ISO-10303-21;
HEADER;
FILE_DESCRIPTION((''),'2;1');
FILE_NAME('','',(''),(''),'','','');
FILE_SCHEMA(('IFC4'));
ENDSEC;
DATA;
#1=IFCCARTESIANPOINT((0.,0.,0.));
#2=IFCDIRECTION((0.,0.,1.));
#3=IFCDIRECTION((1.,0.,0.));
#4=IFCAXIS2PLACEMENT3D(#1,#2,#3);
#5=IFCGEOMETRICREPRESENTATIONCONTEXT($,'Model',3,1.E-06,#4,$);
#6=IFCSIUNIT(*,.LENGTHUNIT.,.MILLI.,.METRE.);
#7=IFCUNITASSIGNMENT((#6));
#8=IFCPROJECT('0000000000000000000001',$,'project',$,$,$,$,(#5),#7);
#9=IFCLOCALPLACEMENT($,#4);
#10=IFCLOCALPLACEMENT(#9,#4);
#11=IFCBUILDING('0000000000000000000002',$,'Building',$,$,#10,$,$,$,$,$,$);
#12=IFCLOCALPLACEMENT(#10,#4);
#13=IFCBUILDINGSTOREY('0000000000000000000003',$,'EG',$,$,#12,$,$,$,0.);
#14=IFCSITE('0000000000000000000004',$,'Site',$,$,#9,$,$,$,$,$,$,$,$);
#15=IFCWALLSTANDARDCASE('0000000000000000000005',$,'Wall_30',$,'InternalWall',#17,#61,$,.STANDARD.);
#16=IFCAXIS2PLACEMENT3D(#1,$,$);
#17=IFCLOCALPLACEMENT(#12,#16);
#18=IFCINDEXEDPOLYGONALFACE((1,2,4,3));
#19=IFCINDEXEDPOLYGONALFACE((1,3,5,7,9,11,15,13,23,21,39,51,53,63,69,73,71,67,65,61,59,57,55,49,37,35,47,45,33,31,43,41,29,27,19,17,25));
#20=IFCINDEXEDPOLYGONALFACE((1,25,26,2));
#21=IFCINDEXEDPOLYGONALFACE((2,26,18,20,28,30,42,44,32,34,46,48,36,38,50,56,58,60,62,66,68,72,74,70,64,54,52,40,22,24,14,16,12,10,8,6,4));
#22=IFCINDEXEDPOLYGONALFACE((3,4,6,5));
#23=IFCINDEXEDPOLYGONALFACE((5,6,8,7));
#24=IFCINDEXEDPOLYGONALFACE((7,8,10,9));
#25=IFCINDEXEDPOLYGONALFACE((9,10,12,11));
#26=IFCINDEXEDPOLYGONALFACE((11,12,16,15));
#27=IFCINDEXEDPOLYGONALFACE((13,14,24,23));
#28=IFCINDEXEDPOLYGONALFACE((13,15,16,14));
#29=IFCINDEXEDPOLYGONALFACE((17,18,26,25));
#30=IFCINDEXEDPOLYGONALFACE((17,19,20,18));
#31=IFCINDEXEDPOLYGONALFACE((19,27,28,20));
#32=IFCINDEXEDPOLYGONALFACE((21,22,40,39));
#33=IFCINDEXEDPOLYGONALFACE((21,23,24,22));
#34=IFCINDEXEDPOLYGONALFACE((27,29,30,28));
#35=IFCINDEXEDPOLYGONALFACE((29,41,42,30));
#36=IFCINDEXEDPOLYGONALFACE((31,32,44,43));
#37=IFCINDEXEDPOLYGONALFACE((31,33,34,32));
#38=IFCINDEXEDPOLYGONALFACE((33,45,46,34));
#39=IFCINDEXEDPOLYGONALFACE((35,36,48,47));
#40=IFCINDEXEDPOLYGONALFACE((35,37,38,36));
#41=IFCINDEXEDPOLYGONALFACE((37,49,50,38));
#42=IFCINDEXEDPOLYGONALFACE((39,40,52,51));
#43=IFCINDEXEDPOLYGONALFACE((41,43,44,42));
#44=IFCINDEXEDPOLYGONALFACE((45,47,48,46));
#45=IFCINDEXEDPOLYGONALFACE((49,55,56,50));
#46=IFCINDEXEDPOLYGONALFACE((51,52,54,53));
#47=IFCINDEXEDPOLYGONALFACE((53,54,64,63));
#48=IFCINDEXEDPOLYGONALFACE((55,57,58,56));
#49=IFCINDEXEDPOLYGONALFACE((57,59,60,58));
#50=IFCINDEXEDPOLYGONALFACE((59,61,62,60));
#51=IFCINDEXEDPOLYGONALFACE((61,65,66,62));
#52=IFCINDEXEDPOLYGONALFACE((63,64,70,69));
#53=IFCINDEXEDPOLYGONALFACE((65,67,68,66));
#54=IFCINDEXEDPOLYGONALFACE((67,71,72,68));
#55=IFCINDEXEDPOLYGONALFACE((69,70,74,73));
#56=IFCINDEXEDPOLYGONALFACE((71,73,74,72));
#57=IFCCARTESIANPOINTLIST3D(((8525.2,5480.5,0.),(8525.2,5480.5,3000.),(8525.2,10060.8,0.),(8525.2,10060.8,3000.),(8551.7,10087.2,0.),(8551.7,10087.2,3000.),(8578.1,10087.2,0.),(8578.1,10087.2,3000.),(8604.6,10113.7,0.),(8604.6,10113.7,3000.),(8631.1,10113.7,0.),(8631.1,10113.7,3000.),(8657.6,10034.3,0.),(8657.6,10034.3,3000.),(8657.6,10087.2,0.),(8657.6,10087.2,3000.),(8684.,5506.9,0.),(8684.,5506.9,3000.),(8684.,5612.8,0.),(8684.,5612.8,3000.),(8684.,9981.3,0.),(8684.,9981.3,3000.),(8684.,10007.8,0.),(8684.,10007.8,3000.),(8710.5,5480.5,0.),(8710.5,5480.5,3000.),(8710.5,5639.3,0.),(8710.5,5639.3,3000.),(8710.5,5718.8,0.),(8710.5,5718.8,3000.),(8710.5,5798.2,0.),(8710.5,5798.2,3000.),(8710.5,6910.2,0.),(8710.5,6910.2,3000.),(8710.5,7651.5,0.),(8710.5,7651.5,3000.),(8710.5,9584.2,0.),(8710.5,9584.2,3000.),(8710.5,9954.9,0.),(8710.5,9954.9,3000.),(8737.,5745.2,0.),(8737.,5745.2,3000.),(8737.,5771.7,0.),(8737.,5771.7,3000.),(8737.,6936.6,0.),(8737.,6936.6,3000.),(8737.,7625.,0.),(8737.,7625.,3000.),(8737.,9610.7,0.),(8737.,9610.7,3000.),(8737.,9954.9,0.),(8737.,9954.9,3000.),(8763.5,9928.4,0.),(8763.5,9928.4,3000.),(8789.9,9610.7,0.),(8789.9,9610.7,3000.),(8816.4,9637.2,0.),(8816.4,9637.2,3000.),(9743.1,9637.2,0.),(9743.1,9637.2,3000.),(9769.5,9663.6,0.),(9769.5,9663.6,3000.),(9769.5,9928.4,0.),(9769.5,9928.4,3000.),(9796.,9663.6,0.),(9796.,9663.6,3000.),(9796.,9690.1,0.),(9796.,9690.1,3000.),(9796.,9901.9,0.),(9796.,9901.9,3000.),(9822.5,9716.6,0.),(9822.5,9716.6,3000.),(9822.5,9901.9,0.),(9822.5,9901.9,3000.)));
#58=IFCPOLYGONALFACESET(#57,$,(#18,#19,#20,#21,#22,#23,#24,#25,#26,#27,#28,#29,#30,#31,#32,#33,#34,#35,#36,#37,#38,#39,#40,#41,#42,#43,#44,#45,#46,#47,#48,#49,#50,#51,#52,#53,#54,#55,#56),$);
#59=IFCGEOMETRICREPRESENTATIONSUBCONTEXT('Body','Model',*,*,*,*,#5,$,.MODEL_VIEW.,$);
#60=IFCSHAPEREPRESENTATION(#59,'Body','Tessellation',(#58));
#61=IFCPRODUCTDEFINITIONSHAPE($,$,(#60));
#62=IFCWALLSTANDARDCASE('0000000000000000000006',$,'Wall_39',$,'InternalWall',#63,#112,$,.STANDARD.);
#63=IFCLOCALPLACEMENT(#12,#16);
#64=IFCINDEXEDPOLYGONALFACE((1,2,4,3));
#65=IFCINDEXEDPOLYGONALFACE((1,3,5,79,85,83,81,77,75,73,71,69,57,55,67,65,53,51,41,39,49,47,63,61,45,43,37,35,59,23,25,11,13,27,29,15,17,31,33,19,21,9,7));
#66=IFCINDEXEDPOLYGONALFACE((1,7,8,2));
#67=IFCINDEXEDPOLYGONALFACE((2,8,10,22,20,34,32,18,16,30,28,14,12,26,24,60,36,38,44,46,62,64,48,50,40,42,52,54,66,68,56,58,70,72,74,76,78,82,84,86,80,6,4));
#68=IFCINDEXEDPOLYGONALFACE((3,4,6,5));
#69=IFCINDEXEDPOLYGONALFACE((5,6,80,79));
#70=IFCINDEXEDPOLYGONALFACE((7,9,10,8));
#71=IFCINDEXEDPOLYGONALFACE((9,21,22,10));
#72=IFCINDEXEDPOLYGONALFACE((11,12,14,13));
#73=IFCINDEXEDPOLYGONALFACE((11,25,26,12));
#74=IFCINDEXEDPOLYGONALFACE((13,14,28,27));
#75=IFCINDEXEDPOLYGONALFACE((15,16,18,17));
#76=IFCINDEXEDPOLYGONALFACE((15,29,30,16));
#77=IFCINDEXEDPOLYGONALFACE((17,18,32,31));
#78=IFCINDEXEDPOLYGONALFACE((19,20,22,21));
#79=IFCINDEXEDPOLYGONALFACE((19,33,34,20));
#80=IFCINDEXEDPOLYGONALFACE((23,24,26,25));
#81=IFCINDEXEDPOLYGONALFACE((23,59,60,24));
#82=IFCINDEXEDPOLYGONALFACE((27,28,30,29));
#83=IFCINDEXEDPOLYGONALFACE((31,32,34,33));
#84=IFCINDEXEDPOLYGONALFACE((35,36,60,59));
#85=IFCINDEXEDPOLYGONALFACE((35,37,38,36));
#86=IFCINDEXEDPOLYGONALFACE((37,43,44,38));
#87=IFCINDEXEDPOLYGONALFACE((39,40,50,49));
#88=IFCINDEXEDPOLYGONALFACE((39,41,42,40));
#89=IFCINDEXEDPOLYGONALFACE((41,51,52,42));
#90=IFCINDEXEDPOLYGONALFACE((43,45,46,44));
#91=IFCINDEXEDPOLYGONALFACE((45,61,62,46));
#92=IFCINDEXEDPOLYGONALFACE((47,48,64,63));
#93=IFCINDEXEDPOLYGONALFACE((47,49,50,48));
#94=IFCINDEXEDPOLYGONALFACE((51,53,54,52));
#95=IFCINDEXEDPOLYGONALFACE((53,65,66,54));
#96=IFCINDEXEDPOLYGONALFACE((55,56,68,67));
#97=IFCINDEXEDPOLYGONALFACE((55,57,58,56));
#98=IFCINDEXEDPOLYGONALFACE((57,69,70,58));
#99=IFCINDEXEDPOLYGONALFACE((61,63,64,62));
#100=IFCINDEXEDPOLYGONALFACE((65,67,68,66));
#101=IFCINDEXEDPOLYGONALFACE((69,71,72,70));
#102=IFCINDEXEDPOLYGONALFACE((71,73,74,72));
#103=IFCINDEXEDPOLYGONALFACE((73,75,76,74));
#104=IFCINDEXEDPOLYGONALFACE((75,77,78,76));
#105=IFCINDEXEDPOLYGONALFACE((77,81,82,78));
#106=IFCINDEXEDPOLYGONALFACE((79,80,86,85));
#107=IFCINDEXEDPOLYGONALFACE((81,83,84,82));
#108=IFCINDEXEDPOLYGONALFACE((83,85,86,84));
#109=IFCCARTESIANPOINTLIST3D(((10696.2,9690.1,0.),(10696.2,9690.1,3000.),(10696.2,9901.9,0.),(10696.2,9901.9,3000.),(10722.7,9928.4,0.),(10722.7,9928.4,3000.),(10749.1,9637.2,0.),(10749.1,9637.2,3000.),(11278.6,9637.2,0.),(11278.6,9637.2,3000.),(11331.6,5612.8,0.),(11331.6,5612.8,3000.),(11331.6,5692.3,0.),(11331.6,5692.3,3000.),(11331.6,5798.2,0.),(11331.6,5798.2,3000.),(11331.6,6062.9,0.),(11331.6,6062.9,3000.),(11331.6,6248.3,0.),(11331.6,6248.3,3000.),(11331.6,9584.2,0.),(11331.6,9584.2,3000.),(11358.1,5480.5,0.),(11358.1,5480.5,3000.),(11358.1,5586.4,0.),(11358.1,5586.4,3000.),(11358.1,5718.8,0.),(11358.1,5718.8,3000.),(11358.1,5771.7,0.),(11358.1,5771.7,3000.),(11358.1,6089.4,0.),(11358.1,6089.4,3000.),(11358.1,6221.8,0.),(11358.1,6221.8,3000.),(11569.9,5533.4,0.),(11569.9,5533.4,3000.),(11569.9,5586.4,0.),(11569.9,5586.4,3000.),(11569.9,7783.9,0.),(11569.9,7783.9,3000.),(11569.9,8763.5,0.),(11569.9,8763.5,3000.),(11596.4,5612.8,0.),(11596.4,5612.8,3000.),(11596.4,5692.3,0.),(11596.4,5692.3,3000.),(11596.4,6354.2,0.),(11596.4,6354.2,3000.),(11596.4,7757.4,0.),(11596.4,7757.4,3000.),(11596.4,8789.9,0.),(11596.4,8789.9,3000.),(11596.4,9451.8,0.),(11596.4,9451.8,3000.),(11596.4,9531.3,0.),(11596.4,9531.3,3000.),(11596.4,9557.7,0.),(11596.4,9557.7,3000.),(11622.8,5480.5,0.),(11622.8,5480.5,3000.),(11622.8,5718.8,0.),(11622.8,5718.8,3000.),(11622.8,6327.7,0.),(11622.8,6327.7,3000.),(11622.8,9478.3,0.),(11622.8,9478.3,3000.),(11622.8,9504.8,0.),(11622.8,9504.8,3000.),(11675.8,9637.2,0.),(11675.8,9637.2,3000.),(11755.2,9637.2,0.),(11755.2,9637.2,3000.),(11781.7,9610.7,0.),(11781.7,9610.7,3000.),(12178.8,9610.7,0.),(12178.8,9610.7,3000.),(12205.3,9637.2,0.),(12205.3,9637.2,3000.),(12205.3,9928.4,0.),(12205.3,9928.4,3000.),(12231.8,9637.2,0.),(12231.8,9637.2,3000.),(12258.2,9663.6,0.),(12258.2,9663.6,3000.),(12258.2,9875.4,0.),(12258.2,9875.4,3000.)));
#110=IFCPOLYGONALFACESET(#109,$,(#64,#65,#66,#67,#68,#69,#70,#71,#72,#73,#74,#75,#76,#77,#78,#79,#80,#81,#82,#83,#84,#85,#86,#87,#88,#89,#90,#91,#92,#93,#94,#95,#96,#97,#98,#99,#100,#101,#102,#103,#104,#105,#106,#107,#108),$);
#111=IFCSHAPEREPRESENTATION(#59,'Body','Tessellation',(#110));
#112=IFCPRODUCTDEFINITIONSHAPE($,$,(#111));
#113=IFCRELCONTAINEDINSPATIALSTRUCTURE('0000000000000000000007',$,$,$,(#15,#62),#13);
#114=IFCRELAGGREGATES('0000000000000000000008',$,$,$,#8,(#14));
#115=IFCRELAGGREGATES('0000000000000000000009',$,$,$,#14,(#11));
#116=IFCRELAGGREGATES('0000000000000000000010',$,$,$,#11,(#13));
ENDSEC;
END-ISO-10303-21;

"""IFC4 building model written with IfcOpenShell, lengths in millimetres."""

from ifc_helpers import new_model, si_unit, frame, origin_with_axes, place, context, subcontext, project, spatial, polyline, outline, extrude, element, save


model = new_model("IFC4")

# Units and contexts
model_context = context("Model", 3, precision=1e-06, world=origin_with_axes())
body_context = subcontext(model_context, "Body", "Model", "MODEL_VIEW")
ifc_project = project(units=[si_unit("LENGTHUNIT", "METRE", prefix="MILLI")], contexts=[model_context])

# Site, building, storey
site_placement = place(None, origin_with_axes())
site = spatial("IfcSite", under=ifc_project, at=site_placement, Name="Site")
building_placement = place(site_placement, origin_with_axes())
building = spatial("IfcBuilding", under=site, at=building_placement, Name="Building")
storey_placement = place(building_placement, origin_with_axes())
storey = spatial("IfcBuildingStorey", under=building, at=storey_placement, Name="EG", Elevation=0.0)

# Walls
for number, where, z_axis, x_axis, name in (
    (1, (0.0, 0.0, 0.0), (0.0, 0.0, 1.0), (1.0, 0.0, 0.0), "Wall_30"),
):
    element("IfcWallStandardCase", number, at=place(storey_placement, frame(where, z_axis=z_axis, x_axis=x_axis)), inside=storey, Name=name, ObjectType="InternalWall", PredefinedType="STANDARD", context=body_context, shape_type="SweptSolid", body=[
        extrude(outline(polyline([(8525.2, 5480.5, 0.0), (8525.2, 10060.8, 0.0), (8551.7, 10087.2, 0.0), (8578.1, 10087.2, 0.0), (8604.6, 10113.7, 0.0), (8631.1, 10113.7, 0.0), (8657.6, 10087.2, 0.0), (8657.6, 10034.3, 0.0), (8684.0, 10007.8, 0.0), (8684.0, 9981.3, 0.0), (8710.5, 9954.9, 0.0), (8737.0, 9954.9, 0.0), (8763.5, 9928.4, 0.0), (9769.5, 9928.4, 0.0), (9796.0, 9901.9, 0.0), (9822.5, 9901.9, 0.0), (9822.5, 9716.6, 0.0), (9796.0, 9690.1, 0.0), (9796.0, 9663.6, 0.0), (9769.5, 9663.6, 0.0), (9743.1, 9637.2, 0.0), (8816.4, 9637.2, 0.0), (8789.9, 9610.7, 0.0), (8737.0, 9610.7, 0.0), (8710.5, 9584.2, 0.0), (8710.5, 7651.5, 0.0), (8737.0, 7625.0, 0.0), (8737.0, 6936.6, 0.0), (8710.5, 6910.2, 0.0), (8710.5, 5798.2, 0.0), (8737.0, 5771.7, 0.0), (8737.0, 5745.2, 0.0), (8710.5, 5718.8, 0.0), (8710.5, 5639.3, 0.0), (8684.0, 5612.8, 0.0), (8684.0, 5506.9, 0.0), (8710.5, 5480.5, 0.0), (8525.2, 5480.5, 0.0)])), origin_with_axes(), (0.0, 0.0, 1.0), 3000.0),
    ])
wall_1_placement = place(storey_placement, origin_with_axes())
element("IfcWallStandardCase", 2, at=wall_1_placement, inside=storey, Name="Wall_39", ObjectType="InternalWall", PredefinedType="STANDARD", context=body_context, shape_type="SweptSolid", body=[
    extrude(outline(polyline([(11358.1, 5480.5, 0.0), (11358.1, 5586.4, 0.0), (11331.6, 5612.8, 0.0), (11331.6, 5692.3, 0.0), (11358.1, 5718.8, 0.0), (11358.1, 5771.7, 0.0), (11331.6, 5798.2, 0.0), (11331.6, 6062.9, 0.0), (11358.1, 6089.4, 0.0), (11358.1, 6221.8, 0.0), (11331.6, 6248.3, 0.0), (11331.6, 9584.2, 0.0), (11278.6, 9637.2, 0.0), (10749.1, 9637.2, 0.0), (10696.2, 9690.1, 0.0), (10696.2, 9901.9, 0.0), (10722.7, 9928.4, 0.0), (12205.3, 9928.4, 0.0), (12258.2, 9875.4, 0.0), (12258.2, 9663.6, 0.0), (12231.8, 9637.2, 0.0), (12205.3, 9637.2, 0.0), (12178.8, 9610.7, 0.0), (11781.7, 9610.7, 0.0), (11755.2, 9637.2, 0.0), (11675.8, 9637.2, 0.0), (11596.4, 9557.7, 0.0), (11596.4, 9531.3, 0.0), (11622.8, 9504.8, 0.0), (11622.8, 9478.3, 0.0), (11596.4, 9451.8, 0.0), (11596.4, 8789.9, 0.0), (11569.9, 8763.5, 0.0), (11569.9, 7783.9, 0.0), (11596.4, 7757.4, 0.0), (11596.4, 6354.2, 0.0), (11622.8, 6327.7, 0.0), (11622.8, 5718.8, 0.0), (11596.4, 5692.3, 0.0), (11596.4, 5612.8, 0.0), (11569.9, 5586.4, 0.0), (11569.9, 5533.4, 0.0), (11622.8, 5480.5, 0.0), (11358.1, 5480.5, 0.0)])), origin_with_axes(), (0.0, 0.0, 1.0), 3000.0),
])

save(model, "model.ifc")
